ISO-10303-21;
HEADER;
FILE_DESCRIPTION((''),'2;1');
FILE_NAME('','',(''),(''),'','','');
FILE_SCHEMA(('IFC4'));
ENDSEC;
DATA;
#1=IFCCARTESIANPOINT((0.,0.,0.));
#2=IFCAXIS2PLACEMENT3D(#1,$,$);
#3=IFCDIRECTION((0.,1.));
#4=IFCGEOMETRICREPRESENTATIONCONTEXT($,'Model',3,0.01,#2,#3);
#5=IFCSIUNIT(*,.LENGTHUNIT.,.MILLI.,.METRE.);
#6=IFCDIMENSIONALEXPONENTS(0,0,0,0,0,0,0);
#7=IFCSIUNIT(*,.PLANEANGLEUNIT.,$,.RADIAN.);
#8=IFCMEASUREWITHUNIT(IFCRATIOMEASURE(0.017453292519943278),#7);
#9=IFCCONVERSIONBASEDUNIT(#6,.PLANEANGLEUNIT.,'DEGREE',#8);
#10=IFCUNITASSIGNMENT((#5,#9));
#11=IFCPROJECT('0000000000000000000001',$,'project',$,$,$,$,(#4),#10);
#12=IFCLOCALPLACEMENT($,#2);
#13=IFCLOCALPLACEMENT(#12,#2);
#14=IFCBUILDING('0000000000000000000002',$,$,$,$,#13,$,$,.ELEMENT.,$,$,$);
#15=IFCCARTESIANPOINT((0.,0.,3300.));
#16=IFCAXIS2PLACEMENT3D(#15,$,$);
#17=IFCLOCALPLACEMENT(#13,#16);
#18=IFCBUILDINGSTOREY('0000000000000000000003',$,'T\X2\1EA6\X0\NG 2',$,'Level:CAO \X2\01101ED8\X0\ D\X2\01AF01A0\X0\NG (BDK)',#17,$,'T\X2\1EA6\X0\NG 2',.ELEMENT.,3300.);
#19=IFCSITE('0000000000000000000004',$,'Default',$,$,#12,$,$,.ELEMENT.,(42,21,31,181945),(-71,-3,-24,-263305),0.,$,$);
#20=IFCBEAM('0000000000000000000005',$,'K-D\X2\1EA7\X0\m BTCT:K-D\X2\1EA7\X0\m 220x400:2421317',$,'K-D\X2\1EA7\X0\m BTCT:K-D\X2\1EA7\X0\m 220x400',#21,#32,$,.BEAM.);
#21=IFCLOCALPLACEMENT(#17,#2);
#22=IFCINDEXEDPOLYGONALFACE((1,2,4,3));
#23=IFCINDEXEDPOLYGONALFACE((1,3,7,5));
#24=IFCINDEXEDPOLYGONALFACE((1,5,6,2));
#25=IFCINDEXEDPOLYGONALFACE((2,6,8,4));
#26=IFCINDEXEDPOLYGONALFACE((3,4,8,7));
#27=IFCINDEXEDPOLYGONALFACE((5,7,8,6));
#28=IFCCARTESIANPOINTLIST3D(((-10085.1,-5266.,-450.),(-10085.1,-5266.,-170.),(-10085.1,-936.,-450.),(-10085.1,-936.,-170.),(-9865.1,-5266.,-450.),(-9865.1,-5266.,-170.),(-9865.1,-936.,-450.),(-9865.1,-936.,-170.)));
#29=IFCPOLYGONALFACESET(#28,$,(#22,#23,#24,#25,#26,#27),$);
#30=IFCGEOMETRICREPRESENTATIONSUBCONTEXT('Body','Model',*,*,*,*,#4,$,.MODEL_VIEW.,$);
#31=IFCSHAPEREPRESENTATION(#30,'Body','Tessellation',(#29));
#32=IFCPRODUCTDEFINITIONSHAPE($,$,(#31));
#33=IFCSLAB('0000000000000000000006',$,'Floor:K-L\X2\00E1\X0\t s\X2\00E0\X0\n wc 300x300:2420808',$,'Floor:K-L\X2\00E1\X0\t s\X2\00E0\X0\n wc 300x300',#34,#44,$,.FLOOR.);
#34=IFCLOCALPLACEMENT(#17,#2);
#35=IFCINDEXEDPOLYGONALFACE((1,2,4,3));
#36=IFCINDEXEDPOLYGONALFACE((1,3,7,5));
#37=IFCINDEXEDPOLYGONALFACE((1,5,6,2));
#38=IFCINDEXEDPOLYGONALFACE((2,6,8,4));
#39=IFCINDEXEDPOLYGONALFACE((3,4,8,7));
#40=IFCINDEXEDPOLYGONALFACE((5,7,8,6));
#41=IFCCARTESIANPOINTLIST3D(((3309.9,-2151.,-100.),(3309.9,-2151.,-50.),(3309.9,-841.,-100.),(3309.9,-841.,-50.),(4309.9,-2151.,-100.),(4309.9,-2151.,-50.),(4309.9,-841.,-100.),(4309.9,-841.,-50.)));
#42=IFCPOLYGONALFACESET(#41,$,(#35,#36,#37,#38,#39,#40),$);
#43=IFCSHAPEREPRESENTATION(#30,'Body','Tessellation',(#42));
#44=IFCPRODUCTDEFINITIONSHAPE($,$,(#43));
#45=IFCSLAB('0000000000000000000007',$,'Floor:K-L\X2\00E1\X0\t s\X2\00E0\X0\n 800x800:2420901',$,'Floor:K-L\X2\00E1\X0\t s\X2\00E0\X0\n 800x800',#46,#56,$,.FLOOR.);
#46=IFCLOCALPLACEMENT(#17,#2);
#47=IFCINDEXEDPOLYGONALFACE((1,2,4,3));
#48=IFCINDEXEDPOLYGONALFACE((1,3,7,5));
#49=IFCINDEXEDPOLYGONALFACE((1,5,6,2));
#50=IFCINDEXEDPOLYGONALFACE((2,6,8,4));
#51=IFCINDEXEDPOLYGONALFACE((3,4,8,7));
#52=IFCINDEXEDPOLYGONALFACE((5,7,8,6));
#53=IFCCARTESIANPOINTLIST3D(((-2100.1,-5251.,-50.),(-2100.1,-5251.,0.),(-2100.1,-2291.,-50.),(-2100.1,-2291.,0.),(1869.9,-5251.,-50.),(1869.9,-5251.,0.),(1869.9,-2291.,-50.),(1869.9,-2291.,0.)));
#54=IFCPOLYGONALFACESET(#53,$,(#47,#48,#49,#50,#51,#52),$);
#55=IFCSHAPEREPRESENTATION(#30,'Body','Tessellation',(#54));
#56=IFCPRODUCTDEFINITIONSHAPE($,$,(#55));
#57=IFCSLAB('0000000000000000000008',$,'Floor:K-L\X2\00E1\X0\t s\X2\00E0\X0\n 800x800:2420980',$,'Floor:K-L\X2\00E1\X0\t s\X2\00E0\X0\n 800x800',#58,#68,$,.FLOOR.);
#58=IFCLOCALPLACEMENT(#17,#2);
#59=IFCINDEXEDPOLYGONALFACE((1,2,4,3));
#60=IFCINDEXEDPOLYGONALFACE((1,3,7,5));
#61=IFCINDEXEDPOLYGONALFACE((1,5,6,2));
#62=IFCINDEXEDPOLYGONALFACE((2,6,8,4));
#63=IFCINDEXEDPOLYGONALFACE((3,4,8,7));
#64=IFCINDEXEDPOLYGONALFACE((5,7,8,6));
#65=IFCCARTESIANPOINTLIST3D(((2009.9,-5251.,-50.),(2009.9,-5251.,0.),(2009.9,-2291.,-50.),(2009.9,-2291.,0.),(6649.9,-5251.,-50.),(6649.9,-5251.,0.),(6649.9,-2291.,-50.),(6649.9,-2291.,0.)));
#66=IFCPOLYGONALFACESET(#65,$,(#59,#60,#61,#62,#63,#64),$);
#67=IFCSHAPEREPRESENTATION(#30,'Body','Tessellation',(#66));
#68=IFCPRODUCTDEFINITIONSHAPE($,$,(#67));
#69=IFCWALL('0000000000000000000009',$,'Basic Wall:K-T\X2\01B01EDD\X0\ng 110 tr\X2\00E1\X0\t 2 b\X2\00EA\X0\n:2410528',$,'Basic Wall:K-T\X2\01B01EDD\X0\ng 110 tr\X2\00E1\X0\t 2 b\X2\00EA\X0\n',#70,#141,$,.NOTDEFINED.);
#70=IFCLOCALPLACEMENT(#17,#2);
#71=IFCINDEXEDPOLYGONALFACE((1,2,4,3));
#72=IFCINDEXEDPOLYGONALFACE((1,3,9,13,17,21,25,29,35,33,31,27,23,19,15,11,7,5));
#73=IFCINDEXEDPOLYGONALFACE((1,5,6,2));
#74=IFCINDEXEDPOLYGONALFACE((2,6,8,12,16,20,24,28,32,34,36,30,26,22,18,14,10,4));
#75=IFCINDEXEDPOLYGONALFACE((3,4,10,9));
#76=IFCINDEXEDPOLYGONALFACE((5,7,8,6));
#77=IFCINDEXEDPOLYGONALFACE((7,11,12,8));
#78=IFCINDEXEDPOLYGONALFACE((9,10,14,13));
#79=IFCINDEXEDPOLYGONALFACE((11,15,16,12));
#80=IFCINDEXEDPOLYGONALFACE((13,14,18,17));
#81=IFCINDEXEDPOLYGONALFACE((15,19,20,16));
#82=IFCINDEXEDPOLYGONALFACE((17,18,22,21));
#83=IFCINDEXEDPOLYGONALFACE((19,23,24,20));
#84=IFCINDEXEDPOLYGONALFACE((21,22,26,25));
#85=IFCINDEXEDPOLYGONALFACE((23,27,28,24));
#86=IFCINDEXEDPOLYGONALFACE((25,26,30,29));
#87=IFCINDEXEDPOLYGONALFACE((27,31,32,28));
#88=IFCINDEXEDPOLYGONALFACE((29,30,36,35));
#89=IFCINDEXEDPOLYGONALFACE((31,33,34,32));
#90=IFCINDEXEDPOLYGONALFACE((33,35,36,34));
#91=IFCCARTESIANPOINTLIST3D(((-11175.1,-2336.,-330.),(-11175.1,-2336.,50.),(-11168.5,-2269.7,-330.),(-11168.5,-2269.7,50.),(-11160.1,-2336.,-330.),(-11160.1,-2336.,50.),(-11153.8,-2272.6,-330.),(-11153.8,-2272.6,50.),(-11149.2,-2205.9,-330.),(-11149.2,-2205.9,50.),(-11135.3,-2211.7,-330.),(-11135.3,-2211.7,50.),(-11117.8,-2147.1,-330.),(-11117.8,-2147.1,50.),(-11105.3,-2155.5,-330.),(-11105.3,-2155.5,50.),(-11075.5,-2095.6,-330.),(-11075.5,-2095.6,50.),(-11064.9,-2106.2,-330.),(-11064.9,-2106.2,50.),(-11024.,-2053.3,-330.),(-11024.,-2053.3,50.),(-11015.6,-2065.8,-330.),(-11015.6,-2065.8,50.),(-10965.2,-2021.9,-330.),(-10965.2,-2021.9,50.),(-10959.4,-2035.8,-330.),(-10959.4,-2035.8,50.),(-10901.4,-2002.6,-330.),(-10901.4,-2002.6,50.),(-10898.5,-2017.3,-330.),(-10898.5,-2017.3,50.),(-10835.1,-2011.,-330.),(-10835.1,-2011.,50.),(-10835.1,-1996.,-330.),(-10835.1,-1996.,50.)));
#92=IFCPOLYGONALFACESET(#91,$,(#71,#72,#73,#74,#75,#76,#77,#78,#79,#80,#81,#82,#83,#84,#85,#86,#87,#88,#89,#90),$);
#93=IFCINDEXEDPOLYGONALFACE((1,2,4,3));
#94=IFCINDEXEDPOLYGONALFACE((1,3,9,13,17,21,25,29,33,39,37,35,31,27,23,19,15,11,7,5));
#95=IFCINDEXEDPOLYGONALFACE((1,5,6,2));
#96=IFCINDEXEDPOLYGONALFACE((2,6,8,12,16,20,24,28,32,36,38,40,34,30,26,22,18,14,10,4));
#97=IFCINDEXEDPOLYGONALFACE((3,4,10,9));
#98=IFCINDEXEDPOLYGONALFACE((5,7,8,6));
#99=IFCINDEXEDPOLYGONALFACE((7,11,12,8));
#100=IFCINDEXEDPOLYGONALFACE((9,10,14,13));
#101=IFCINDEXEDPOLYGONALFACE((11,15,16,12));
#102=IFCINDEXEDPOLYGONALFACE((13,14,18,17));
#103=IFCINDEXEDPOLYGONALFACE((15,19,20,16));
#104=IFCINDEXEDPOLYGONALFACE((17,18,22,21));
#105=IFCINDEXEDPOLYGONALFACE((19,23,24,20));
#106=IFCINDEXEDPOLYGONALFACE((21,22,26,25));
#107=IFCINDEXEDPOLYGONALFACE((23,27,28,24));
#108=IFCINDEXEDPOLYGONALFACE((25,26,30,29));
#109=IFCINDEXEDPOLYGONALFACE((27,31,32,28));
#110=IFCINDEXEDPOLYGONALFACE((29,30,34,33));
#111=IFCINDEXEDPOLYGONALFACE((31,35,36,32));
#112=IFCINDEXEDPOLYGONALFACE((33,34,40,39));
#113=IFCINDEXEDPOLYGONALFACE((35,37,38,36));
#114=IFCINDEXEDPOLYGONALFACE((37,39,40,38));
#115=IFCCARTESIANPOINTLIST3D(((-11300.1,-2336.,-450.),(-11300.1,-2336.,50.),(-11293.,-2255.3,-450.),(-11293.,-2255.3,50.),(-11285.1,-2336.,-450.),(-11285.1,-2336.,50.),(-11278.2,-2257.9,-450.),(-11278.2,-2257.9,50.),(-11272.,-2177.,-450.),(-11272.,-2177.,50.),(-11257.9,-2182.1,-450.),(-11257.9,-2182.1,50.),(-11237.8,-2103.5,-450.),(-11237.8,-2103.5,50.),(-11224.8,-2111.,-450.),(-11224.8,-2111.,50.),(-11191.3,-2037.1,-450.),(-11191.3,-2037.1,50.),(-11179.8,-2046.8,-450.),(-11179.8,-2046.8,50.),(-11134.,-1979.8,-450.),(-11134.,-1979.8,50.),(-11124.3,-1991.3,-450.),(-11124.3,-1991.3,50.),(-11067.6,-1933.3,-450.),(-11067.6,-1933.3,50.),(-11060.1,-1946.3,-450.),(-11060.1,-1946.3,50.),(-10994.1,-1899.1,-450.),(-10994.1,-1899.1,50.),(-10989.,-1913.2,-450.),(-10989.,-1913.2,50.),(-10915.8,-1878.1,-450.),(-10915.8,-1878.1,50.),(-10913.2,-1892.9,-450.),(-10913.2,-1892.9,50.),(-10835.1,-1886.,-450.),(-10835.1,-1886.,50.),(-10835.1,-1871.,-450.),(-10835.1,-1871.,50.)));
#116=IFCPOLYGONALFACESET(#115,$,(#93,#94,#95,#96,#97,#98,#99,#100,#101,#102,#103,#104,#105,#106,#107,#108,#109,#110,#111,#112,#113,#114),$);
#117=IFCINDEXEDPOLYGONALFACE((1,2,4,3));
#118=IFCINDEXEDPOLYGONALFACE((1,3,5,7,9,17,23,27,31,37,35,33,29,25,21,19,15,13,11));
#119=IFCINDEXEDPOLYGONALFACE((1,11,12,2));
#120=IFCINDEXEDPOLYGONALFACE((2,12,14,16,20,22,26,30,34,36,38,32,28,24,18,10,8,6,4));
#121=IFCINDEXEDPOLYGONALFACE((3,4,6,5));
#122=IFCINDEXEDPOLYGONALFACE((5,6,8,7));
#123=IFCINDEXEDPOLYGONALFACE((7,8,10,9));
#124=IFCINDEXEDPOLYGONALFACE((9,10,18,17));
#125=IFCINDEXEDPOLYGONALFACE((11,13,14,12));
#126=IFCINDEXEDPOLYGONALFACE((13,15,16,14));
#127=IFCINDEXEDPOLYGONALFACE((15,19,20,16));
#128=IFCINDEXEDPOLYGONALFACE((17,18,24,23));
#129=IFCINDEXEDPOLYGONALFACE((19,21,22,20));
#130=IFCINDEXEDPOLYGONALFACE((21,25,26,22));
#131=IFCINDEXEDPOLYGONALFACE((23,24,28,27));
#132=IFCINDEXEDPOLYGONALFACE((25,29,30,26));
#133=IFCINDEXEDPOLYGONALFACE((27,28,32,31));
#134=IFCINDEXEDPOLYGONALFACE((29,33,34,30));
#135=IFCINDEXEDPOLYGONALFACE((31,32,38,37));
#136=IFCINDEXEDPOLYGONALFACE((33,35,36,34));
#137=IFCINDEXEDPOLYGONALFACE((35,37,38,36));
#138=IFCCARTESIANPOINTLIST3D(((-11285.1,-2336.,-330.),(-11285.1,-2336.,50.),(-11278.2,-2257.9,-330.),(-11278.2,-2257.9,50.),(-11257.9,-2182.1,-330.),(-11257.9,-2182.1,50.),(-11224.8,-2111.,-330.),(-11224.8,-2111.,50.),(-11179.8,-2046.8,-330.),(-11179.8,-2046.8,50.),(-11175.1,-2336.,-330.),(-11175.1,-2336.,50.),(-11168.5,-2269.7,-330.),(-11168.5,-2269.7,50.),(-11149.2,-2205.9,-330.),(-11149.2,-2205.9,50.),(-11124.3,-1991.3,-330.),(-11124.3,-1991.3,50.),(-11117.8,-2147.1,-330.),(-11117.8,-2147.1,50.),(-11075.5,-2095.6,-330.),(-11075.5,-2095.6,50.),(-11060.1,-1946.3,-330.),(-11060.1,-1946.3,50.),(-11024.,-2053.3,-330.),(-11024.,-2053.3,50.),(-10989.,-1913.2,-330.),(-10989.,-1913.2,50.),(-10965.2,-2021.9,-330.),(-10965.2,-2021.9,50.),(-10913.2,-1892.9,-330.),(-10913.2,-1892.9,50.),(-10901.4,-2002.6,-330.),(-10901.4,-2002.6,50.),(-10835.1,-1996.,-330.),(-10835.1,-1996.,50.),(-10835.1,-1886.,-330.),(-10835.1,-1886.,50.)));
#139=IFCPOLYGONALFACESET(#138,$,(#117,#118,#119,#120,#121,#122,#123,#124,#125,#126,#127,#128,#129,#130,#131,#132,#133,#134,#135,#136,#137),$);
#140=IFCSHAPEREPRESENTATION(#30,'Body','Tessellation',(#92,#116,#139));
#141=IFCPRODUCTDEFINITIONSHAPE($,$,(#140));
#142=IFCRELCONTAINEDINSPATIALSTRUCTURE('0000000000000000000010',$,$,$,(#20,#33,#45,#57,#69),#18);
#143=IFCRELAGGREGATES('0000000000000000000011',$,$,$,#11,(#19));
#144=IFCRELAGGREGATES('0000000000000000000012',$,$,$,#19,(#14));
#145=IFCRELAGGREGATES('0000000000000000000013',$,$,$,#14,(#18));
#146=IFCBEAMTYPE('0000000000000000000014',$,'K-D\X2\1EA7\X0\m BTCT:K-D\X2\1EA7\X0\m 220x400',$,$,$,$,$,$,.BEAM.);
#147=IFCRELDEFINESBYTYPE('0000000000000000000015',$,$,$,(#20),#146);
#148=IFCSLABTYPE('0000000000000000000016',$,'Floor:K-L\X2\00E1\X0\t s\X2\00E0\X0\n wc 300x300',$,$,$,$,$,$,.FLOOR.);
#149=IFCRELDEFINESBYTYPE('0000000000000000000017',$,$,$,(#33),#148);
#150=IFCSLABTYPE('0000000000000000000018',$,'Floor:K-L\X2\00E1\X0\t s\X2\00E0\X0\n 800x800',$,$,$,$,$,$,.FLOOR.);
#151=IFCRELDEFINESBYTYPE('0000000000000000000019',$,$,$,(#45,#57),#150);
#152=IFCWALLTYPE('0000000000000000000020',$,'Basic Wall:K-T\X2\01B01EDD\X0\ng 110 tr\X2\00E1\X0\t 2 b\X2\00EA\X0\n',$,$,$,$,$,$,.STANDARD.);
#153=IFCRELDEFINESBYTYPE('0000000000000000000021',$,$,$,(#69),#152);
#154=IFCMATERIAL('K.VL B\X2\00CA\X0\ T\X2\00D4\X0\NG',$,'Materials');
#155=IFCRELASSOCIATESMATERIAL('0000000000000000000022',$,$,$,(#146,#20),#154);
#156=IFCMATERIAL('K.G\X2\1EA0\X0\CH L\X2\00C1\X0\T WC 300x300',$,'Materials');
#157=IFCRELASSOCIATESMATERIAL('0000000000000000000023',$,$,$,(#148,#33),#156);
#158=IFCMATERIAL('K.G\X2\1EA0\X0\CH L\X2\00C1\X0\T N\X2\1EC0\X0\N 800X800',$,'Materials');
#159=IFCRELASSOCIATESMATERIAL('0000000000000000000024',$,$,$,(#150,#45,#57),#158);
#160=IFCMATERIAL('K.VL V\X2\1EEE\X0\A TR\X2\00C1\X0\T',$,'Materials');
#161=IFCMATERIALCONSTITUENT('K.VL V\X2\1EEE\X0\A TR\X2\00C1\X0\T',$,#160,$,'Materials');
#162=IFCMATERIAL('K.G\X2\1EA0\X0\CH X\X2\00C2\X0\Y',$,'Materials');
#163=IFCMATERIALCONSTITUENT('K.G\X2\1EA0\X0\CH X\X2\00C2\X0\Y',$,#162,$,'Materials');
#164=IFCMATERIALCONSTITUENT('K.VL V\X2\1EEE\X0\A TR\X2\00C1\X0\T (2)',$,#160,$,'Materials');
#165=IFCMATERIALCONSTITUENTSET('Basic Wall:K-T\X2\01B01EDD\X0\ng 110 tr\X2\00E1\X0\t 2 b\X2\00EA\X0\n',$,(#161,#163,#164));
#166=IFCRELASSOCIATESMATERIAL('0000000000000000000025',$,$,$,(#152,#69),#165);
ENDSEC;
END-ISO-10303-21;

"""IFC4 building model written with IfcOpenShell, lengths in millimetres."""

from ifc_helpers import new_model, entity, si_unit, converted_unit, direction, frame, origin, place, context, subcontext, project, spatial, line, arc, indexed_curve, outline, extrude, source, transform, mapped, material, constituent, constituent_set, type_object, type_shapes, element, save


model = new_model("IFC4")

# Units and contexts
model_context = context("Model", 3, precision=0.01, world=origin(), true_north=direction((0.0, 1.0)))
body_context = subcontext(model_context, "Body", "Model", "MODEL_VIEW")
ifc_project = project(units=[si_unit("LENGTHUNIT", "METRE", prefix="MILLI"), converted_unit("PLANEANGLEUNIT", "DEGREE", entity("IfcRatioMeasure", 0.017453292519943278), si_unit("PLANEANGLEUNIT", "RADIAN"), dimensions=[0, 0, 0, 0, 0, 0, 0])], contexts=[model_context])

# Site, building, storey
site_placement = place(None, origin())
site = spatial("IfcSite", under=ifc_project, at=site_placement, Name="Default", CompositionType="ELEMENT", RefLatitude=(42, 21, 31, 181945), RefLongitude=(-71, -3, -24, -263305), RefElevation=0.0)
building_placement = place(site_placement, origin())
building = spatial("IfcBuilding", under=site, at=building_placement, CompositionType="ELEMENT")
storey_placement = place(building_placement, frame((0.0, 0.0, 3300.0)))
storey = spatial("IfcBuildingStorey", under=building, at=storey_placement, Name="TẦNG 2", ObjectType="Level:CAO ĐỘ DƯƠNG (BDK)", LongName="TẦNG 2", CompositionType="ELEMENT", Elevation=3300.0)

# Beam
ifc_material_1 = material(Name="K.VL BÊ TÔNG", Category="Materials")
beam_type = type_object("IfcBeamType", Name="K-Dầm BTCT:K-Dầm 220x400", PredefinedType="BEAM", material=ifc_material_1)
shared_shape_1 = source(origin(), body_context, "Body", "SweptSolid", [
    extrude(outline(indexed_curve([(-110.0, -140.0), (110.0, -140.0), (110.0, 140.0), (-110.0, 140.0), (-110.0, -140.0)], self_intersect=False)), frame((-9975.1, -5266.0, 2990.0), z_axis=(0.0, 1.0, 0.0), x_axis=(-1.0, 0.0, 0.0)), (0.0, 0.0, 1.0), 4330.0),
])
type_shapes(beam_type, [shared_shape_1])
beam_placement = place(storey_placement, frame((0.0, 0.0, -3300.0)))
element("IfcBeam", 1, at=beam_placement, inside=storey, type_object=beam_type, material=ifc_material_1, Name="K-Dầm BTCT:K-Dầm 220x400:2421317", ObjectType="K-Dầm BTCT:K-Dầm 220x400", PredefinedType="BEAM", context=body_context, shape_type="MappedRepresentation", body=[
    mapped(shared_shape_1, transform((0.0, 0.0, 0.0), scale=1.0)),
])

# Slabs
ifc_material_2 = material(Name="K.GẠCH LÁT WC 300x300", Category="Materials")
slab_type_1 = type_object("IfcSlabType", Name="Floor:K-Lát sàn wc 300x300", PredefinedType="FLOOR", material=ifc_material_2)
slab_1_placement = place(storey_placement, origin())
element("IfcSlab", 2, at=slab_1_placement, inside=storey, type_object=slab_type_1, material=ifc_material_2, Name="Floor:K-Lát sàn wc 300x300:2420808", ObjectType="Floor:K-Lát sàn wc 300x300", PredefinedType="FLOOR", context=body_context, shape_type="SweptSolid", body=[
    extrude(outline(indexed_curve([(-655.0, -500.0), (655.0, -500.0), (655.0, 500.0), (-655.0, 500.0), (-655.0, -500.0)], self_intersect=False)), frame((3809.9, -1496.0, -50.0), z_axis=(0.0, 0.0, -1.0), x_axis=(0.0, 1.0, 0.0)), (0.0, 0.0, 1.0), 50.0),
])
ifc_material_3 = material(Name="K.GẠCH LÁT NỀN 800X800", Category="Materials")
slab_type_2 = type_object("IfcSlabType", Name="Floor:K-Lát sàn 800x800", PredefinedType="FLOOR", material=ifc_material_3)
slab_2_placement = place(storey_placement, origin())
element("IfcSlab", 3, at=slab_2_placement, inside=storey, type_object=slab_type_2, material=ifc_material_3, Name="Floor:K-Lát sàn 800x800:2420901", ObjectType="Floor:K-Lát sàn 800x800", PredefinedType="FLOOR", context=body_context, shape_type="SweptSolid", body=[
    extrude(outline(indexed_curve([(-1480.0, -1985.0), (1480.0, -1985.0), (1480.0, 1985.0), (-1480.0, 1985.0), (-1480.0, -1985.0)], self_intersect=False)), frame((-115.1, -3771.0, 0.0), z_axis=(0.0, 0.0, -1.0), x_axis=(0.0, 1.0, 0.0)), (0.0, 0.0, 1.0), 50.0),
])
slab_3_placement = place(storey_placement, origin())
element("IfcSlab", 4, at=slab_3_placement, inside=storey, type_object=slab_type_2, material=ifc_material_3, Name="Floor:K-Lát sàn 800x800:2420980", ObjectType="Floor:K-Lát sàn 800x800", PredefinedType="FLOOR", context=body_context, shape_type="SweptSolid", body=[
    extrude(outline(indexed_curve([(-1480.0, -2320.0), (1480.0, -2320.0), (1480.0, 2320.0), (-1480.0, 2320.0), (-1480.0, -2320.0)], self_intersect=False)), frame((4329.9, -3771.0, 0.0), z_axis=(0.0, 0.0, -1.0), x_axis=(0.0, 1.0, 0.0)), (0.0, 0.0, 1.0), 50.0),
])

# Shared definitions
ifc_material_4 = material(Name="K.VL VỮA TRÁT", Category="Materials")
ifc_material_5 = material(Name="K.GẠCH XÂY", Category="Materials")

# Wall
ifc_constituent_1 = constituent(ifc_material_4, Name="K.VL VỮA TRÁT", Category="Materials")
ifc_constituent_2 = constituent(ifc_material_5, Name="K.GẠCH XÂY", Category="Materials")
ifc_constituent_3 = constituent(ifc_material_4, Name="K.VL VỮA TRÁT (2)", Category="Materials")
ifc_constituent_set_1 = constituent_set(constituents=[ifc_constituent_1, ifc_constituent_2, ifc_constituent_3], Name="Basic Wall:K-Tường 110 trát 2 bên")
wall_type_1 = type_object("IfcWallType", Name="Basic Wall:K-Tường 110 trát 2 bên", PredefinedType="STANDARD", material=ifc_constituent_set_1)
wall_1_placement = place(storey_placement, frame((-11230.1, -2336.0, -450.0)))
element("IfcWall", 5, at=wall_1_placement, inside=storey, type_object=wall_type_1, material=ifc_constituent_set_1, Name="Basic Wall:K-Tường 110 trát 2 bên:2410528", ObjectType="Basic Wall:K-Tường 110 trát 2 bên", PredefinedType="NOTDEFINED", context=body_context, shape_type="SweptSolid", body=[
    extrude(outline(indexed_curve([(158.8, -166.2), (173.8, -166.3), (74.2, 74.2), (-166.3, 173.8), (-166.3, 158.8), (63.6, 63.6)], segments=[line(1, 2), arc(2, 3, 4), line(4, 5), arc(5, 6, 1)], self_intersect=False)), frame((228.7, 166.3, 120.0), z_axis=(0.0, 0.0, 1.0), x_axis=(0.0, 1.0, 0.0)), (0.0, 0.0, 1.0), 380.0),
    extrude(outline(indexed_curve([(-236.2, 228.8), (-100.1, -100.1), (228.7, -236.3), (228.8, -221.3), (-89.4, -89.4), (-221.2, 228.8)], segments=[arc(1, 2, 3), line(3, 4), arc(4, 5, 6), line(6, 1)], self_intersect=False)), frame((166.2, 228.8, 0.0), z_axis=(0.0, 0.0, -1.0), x_axis=(1.0, 0.0, 0.0)), (0.0, 0.0, -1.0), 500.0),
    extrude(outline(indexed_curve([(144.5, -196.0), (254.5, -194.9), (119.4, 121.9), (-200.1, 250.4), (-199.0, 140.4), (42.5, 43.4)], segments=[line(1, 2), arc(2, 3, 4), line(4, 5), arc(5, 6, 1)], self_intersect=False)), frame((197.5, 197.5, 120.0), z_axis=(0.0, 0.0, -1.0), x_axis=(-0.999946, -0.010416, 0.0)), (0.0, 0.0, -1.0), 380.0),
])

save(model, "model.ifc")
